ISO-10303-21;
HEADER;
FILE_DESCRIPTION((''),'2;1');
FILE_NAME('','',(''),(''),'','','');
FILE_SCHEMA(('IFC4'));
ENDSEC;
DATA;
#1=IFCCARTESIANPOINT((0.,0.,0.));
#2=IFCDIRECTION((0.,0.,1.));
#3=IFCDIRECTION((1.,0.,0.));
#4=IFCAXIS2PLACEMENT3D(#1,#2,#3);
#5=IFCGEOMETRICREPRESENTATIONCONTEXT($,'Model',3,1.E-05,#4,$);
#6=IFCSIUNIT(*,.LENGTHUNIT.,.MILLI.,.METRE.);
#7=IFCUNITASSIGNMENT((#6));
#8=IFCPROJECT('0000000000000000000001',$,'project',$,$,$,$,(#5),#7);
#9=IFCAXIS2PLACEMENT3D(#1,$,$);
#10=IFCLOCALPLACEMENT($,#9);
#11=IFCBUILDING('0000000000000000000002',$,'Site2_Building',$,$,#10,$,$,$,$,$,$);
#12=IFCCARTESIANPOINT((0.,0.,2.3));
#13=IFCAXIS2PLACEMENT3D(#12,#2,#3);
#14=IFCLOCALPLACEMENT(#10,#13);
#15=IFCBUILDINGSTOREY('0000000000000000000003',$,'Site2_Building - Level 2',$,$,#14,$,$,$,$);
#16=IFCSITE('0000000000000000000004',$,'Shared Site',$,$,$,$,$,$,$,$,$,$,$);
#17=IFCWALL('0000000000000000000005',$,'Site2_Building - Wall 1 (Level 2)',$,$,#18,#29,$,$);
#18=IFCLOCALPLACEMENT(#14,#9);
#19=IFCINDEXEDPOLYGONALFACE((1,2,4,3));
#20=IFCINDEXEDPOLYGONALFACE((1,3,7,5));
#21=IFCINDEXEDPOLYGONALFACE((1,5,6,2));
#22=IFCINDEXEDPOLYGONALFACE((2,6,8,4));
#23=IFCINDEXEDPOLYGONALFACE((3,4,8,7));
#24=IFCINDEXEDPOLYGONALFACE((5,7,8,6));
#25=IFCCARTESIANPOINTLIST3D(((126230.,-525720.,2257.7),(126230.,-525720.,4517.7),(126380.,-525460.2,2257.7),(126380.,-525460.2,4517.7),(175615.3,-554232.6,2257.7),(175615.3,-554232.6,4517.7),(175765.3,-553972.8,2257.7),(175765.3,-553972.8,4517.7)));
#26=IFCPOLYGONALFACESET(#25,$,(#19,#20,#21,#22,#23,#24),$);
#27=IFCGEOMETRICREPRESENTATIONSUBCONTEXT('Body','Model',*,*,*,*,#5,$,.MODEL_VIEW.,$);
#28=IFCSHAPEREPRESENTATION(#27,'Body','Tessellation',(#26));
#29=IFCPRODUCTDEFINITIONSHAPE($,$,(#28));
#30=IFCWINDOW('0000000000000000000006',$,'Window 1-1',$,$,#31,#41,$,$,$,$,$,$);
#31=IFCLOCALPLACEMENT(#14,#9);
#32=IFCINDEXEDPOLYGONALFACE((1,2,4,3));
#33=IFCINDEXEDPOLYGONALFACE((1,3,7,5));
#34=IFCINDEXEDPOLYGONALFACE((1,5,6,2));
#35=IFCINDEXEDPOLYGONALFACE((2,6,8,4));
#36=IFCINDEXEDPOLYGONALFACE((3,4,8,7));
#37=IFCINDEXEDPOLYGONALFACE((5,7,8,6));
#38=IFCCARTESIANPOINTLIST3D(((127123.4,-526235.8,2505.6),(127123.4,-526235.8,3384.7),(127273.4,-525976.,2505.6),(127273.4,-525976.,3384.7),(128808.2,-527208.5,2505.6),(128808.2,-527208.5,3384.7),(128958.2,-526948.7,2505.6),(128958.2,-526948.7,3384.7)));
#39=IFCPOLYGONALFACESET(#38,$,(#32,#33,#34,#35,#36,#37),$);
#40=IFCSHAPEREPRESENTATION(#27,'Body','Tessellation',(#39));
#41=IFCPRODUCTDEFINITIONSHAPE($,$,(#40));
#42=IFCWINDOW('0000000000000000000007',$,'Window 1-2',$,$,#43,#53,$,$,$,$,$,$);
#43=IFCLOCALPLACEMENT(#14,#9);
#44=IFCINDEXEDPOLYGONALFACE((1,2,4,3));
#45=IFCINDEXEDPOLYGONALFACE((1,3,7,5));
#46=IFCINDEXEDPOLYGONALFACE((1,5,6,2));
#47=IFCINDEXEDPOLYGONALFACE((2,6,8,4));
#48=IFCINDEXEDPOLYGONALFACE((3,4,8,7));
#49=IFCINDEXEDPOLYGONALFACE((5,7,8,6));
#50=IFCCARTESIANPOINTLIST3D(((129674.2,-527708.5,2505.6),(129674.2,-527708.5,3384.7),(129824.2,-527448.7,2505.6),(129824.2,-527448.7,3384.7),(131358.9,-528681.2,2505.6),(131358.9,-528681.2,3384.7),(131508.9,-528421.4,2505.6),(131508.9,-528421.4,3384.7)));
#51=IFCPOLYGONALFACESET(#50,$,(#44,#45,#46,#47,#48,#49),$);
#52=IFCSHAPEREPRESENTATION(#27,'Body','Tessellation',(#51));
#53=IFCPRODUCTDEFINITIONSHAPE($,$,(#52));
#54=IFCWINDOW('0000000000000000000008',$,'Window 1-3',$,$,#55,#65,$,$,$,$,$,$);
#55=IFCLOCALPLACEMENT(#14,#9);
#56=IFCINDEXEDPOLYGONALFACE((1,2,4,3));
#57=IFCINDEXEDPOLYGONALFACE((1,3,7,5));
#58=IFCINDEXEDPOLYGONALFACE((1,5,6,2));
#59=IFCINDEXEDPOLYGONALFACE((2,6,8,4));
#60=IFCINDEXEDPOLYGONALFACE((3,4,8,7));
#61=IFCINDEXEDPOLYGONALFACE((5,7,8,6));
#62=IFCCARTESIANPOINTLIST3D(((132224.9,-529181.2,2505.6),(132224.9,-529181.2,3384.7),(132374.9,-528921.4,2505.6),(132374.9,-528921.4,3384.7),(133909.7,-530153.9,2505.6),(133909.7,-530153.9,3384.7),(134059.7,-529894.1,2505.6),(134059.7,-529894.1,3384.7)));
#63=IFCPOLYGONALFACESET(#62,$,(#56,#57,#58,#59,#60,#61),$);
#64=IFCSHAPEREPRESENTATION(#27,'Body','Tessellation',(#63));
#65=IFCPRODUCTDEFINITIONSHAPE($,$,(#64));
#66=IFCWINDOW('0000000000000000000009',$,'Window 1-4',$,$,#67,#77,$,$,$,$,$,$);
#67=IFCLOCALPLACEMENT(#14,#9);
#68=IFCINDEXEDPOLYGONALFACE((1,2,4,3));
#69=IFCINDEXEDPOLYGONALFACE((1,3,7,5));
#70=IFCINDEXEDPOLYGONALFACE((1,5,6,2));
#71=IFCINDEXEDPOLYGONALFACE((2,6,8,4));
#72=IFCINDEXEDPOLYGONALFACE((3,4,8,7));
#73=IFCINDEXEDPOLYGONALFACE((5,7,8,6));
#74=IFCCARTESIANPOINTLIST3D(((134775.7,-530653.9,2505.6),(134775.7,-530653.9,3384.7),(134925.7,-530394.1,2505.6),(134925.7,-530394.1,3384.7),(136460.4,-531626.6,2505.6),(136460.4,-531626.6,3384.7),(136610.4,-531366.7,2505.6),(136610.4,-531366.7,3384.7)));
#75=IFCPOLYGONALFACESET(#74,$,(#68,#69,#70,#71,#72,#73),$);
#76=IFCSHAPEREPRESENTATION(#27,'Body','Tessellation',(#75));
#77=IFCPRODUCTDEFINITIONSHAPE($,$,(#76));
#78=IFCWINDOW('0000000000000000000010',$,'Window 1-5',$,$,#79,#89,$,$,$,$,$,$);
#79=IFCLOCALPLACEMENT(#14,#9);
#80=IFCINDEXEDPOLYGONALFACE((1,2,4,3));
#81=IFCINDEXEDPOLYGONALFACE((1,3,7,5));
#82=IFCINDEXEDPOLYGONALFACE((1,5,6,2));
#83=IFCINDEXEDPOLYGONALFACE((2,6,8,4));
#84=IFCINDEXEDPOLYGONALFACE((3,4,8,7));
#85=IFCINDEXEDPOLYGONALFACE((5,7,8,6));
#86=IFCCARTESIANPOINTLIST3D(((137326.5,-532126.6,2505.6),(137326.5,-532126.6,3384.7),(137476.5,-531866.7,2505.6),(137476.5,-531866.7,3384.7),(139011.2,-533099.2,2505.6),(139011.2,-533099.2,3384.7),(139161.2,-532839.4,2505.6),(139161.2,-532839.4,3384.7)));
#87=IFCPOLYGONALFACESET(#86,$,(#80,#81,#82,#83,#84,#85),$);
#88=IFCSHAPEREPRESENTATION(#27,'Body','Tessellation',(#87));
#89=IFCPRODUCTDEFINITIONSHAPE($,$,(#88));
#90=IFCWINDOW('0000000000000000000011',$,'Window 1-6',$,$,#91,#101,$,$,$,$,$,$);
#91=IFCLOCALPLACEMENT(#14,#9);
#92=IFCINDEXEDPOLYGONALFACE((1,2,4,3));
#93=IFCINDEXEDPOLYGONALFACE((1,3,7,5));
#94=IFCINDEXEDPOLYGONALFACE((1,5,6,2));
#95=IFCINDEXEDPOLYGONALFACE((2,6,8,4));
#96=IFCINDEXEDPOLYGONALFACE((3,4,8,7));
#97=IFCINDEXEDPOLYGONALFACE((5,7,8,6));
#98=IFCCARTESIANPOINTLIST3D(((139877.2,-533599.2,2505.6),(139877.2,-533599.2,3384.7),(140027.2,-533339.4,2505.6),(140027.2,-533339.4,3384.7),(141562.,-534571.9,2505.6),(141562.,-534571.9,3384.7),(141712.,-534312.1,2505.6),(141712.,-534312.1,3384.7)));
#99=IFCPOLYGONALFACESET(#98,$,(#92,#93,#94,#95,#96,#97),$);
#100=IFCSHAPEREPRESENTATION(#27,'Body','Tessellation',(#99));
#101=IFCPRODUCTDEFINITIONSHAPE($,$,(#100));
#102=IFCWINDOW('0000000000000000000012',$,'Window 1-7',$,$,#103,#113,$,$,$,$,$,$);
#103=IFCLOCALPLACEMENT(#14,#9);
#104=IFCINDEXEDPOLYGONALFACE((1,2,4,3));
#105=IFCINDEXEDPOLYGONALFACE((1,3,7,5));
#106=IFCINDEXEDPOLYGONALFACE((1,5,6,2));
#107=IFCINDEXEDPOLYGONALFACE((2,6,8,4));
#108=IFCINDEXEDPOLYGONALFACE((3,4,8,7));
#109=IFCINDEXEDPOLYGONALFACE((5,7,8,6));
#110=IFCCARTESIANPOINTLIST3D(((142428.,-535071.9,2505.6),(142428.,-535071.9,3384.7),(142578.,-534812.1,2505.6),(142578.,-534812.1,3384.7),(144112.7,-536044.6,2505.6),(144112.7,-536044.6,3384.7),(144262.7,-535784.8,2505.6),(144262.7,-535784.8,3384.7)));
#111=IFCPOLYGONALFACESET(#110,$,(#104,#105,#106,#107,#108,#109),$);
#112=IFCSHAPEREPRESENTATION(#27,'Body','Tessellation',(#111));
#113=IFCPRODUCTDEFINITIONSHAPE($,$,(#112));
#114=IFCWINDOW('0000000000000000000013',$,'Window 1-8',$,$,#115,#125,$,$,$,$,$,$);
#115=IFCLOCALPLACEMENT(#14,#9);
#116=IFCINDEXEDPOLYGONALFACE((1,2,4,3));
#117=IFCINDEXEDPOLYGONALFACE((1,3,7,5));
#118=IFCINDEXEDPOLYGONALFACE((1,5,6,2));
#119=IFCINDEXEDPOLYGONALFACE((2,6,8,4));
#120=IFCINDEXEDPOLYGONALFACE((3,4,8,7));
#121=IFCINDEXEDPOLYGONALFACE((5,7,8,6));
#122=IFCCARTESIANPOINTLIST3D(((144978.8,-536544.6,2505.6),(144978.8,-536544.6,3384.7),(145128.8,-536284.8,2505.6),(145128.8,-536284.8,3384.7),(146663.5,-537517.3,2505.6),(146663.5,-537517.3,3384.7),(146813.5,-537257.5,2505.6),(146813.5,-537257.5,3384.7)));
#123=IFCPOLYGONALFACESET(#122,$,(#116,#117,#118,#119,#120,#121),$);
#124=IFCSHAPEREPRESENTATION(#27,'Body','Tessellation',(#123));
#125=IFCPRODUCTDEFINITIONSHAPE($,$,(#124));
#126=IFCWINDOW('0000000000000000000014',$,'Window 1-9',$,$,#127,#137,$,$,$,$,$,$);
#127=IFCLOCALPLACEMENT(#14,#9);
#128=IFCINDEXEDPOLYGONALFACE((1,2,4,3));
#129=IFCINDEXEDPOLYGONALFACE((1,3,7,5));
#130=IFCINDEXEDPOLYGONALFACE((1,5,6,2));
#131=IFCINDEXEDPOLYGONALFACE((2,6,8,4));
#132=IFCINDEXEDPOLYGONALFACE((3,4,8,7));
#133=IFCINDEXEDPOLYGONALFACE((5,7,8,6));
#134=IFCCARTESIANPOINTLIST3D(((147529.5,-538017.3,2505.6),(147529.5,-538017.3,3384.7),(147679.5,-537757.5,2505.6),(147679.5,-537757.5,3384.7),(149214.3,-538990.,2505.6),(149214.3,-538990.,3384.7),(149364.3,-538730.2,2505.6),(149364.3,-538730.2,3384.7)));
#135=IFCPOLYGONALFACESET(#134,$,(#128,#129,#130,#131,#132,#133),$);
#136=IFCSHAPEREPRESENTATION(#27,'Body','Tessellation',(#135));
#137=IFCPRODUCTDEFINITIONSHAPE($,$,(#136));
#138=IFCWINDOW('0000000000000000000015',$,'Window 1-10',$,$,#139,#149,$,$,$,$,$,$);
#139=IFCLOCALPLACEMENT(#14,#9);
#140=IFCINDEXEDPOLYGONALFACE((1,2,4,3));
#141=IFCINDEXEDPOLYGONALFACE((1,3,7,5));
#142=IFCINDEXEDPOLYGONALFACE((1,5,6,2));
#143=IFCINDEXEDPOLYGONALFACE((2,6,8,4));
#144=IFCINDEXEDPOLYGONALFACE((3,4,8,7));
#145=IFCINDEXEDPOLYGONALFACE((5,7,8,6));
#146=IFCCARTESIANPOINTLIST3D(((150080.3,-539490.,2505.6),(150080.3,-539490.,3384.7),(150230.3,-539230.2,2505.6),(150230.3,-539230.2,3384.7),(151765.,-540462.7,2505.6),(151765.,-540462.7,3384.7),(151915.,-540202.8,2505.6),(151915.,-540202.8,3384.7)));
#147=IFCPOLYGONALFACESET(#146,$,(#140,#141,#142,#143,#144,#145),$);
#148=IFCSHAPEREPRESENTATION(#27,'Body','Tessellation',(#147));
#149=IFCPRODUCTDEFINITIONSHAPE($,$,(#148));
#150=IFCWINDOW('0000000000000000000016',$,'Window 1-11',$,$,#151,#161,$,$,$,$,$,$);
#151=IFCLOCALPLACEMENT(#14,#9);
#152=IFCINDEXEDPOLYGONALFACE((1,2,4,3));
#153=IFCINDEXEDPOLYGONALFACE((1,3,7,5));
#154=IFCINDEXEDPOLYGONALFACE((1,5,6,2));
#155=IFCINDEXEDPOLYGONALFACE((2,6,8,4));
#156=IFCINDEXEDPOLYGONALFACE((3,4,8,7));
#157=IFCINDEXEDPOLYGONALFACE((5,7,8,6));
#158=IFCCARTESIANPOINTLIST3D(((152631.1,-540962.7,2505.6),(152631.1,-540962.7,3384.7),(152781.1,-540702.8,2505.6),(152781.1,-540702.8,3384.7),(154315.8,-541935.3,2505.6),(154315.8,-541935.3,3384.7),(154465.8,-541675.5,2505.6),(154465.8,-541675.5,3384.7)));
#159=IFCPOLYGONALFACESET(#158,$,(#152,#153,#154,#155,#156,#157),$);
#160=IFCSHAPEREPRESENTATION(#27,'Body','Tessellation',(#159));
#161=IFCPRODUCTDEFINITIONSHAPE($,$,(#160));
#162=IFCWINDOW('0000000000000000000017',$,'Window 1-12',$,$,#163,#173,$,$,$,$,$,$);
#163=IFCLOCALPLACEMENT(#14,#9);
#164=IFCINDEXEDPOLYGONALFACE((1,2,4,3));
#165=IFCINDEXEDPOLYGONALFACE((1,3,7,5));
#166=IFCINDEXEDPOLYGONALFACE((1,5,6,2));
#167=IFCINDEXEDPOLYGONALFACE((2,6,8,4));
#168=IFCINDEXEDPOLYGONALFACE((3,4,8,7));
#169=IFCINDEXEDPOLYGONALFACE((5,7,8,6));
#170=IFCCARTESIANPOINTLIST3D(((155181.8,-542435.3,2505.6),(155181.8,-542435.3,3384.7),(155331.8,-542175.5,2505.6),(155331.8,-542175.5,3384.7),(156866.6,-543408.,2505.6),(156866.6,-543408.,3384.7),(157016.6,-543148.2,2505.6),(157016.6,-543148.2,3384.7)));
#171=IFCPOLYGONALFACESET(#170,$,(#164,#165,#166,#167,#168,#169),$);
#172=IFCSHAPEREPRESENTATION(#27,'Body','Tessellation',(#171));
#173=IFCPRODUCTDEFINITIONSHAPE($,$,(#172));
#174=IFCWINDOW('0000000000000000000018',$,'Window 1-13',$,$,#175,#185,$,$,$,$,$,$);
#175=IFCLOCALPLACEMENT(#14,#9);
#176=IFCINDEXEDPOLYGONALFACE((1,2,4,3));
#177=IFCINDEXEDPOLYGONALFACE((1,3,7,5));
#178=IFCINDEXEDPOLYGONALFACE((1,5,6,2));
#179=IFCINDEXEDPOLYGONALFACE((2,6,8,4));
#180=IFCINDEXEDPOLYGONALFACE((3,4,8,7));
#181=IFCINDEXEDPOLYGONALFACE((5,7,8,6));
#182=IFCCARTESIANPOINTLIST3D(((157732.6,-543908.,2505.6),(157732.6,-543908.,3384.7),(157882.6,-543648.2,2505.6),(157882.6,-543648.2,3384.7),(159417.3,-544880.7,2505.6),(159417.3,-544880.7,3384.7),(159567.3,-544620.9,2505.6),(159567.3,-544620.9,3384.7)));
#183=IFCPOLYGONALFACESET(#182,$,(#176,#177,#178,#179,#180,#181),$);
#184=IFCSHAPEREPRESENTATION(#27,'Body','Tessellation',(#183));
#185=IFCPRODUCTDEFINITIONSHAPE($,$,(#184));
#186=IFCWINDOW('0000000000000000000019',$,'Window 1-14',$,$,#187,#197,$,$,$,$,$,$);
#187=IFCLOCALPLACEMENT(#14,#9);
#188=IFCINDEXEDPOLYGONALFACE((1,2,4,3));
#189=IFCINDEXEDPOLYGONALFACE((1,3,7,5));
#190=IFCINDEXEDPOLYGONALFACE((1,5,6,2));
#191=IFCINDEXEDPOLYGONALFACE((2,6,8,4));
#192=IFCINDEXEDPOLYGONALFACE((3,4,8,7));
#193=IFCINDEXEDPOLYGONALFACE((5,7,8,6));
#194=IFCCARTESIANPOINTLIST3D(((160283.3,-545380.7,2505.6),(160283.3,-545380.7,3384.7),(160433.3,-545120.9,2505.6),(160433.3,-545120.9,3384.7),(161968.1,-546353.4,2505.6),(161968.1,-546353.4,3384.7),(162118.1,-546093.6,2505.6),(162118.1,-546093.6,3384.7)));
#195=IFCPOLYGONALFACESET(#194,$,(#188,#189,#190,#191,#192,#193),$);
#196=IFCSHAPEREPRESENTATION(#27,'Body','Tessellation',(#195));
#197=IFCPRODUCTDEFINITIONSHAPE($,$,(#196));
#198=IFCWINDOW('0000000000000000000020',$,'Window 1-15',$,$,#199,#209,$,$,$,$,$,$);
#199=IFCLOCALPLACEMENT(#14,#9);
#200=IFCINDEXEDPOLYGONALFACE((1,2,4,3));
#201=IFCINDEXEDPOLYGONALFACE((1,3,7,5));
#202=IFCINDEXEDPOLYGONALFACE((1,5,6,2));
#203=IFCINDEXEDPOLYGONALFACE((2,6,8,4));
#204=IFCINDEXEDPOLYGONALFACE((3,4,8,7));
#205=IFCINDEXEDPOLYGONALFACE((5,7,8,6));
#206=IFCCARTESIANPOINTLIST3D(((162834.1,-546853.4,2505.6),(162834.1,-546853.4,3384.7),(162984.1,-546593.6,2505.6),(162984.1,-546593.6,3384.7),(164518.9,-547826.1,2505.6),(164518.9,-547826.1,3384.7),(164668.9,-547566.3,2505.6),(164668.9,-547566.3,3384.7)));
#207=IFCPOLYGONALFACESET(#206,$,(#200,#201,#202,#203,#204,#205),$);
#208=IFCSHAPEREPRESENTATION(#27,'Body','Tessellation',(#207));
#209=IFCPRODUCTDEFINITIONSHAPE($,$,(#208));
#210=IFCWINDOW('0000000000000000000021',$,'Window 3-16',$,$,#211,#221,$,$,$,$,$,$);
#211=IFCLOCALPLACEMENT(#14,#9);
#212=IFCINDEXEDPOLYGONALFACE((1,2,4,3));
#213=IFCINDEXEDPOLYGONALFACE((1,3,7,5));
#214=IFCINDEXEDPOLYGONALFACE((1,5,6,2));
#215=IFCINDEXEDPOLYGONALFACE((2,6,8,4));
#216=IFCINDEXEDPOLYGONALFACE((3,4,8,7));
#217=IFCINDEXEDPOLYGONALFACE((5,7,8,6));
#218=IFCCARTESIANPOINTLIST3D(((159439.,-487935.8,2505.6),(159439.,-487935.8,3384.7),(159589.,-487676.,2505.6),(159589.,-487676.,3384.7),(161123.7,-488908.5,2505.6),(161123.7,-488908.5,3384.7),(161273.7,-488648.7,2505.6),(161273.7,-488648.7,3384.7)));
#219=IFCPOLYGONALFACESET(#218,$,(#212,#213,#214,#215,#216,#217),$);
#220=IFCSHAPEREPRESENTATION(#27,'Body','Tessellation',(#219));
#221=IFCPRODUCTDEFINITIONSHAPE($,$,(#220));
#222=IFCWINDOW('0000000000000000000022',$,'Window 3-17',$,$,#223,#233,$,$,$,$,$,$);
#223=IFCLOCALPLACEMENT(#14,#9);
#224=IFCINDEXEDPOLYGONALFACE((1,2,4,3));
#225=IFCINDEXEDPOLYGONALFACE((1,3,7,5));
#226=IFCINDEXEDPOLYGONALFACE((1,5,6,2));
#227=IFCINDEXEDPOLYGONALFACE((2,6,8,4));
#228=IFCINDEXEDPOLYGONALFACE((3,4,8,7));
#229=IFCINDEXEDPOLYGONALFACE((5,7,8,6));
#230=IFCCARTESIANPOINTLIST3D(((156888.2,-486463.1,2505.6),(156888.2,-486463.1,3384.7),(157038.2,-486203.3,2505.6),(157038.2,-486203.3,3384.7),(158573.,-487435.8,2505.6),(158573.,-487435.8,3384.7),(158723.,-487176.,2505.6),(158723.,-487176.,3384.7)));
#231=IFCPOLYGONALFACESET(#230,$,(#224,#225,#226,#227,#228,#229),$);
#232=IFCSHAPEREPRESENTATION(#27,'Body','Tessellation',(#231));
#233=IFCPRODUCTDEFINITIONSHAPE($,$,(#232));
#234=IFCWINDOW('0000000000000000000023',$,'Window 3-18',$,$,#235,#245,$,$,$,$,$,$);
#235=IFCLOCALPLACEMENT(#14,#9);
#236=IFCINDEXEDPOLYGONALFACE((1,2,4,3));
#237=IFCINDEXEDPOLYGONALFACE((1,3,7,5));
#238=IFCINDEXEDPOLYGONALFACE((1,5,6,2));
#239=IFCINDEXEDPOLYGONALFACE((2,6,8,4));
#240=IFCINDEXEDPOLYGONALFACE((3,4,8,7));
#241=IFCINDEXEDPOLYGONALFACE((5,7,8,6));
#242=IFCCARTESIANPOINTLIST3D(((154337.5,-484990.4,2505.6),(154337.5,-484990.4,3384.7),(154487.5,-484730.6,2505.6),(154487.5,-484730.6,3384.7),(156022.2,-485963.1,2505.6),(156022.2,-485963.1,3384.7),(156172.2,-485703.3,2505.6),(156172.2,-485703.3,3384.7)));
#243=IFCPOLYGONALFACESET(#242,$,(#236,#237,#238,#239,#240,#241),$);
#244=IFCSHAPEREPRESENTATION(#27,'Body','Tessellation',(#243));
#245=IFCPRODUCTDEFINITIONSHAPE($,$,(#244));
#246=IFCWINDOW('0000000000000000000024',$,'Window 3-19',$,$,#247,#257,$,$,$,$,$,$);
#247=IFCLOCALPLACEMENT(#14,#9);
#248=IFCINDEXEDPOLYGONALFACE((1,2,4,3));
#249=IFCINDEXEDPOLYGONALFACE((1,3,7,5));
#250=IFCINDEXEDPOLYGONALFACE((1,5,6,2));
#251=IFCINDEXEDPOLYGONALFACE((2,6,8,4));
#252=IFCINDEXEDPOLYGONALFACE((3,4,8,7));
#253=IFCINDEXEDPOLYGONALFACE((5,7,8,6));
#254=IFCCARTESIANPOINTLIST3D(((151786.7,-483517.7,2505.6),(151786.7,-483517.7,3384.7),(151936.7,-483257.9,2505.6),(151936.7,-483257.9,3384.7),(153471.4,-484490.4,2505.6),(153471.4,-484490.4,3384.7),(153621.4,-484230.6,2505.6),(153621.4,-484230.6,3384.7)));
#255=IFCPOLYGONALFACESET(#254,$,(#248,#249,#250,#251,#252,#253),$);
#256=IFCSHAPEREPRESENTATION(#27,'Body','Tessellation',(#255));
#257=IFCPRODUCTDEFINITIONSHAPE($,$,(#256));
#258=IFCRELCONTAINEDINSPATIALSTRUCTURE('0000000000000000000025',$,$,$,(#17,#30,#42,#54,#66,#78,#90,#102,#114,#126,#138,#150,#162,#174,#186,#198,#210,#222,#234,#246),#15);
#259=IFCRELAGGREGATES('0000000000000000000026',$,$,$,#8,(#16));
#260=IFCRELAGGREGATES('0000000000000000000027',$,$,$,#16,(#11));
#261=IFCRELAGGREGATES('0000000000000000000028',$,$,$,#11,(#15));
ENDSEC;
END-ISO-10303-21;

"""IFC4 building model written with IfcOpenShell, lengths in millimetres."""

from ifc_helpers import new_model, si_unit, frame, origin, origin_with_axes, place, context, subcontext, project, spatial, indexed_curve, outline, extrude, element, save


model = new_model("IFC4")

# Units and contexts
model_context = context("Model", 3, precision=1e-05, world=origin_with_axes())
body_context = subcontext(model_context, "Body", "Model", "MODEL_VIEW")
ifc_project = project(units=[si_unit("LENGTHUNIT", "METRE", prefix="MILLI")], contexts=[model_context])

# Site, building, storey
site = spatial("IfcSite", under=ifc_project, Name="Shared Site")
building_placement = place(None, origin())
building = spatial("IfcBuilding", under=site, at=building_placement, Name="Site2_Building")
storey_placement = place(building_placement, frame((0.0, 0.0, 2.3), z_axis=(0.0, 0.0, 1.0), x_axis=(1.0, 0.0, 0.0)))
storey = spatial("IfcBuildingStorey", under=building, at=storey_placement, Name="Site2_Building - Level 2")

# Wall
wall_1_placement = place(storey_placement, frame((126230.0, -525720.0, 2257.7), z_axis=(0.0, 0.0, 1.0), x_axis=(0.866025, -0.5, 0.0)))
element("IfcWall", 1, at=wall_1_placement, inside=storey, Name="Site2_Building - Wall 1 (Level 2)", context=body_context, shape_type="SweptSolid", body=[
    extrude(outline(indexed_curve([(0.0, 0.0), (0.0, 300.0), (57025.3, 300.0), (57025.3, 0.0), (0.0, 0.0)], self_intersect=False)), origin_with_axes(), (0.0, 0.0, 1.0), 2260.0),
])

# Windows
for number, where, z_axis, x_axis, name in (
    (2, (127123.4, -526235.8, 2505.6), (0.0, 0.0, 1.0), (0.866025, -0.5, 0.0), "Window 1-1"),
    (3, (129674.2, -527708.5, 2505.6), (0.0, 0.0, 1.0), (0.866025, -0.5, 0.0), "Window 1-2"),
    (4, (132224.9, -529181.2, 2505.6), (0.0, 0.0, 1.0), (0.866025, -0.5, 0.0), "Window 1-3"),
    (5, (134775.7, -530653.9, 2505.6), (0.0, 0.0, 1.0), (0.866025, -0.5, 0.0), "Window 1-4"),
    (6, (137326.5, -532126.6, 2505.6), (0.0, 0.0, 1.0), (0.866025, -0.5, 0.0), "Window 1-5"),
    (7, (139877.2, -533599.2, 2505.6), (0.0, 0.0, 1.0), (0.866025, -0.5, 0.0), "Window 1-6"),
    (8, (142428.0, -535071.9, 2505.6), (0.0, 0.0, 1.0), (0.866025, -0.5, 0.0), "Window 1-7"),
    (9, (144978.8, -536544.6, 2505.6), (0.0, 0.0, 1.0), (0.866025, -0.5, 0.0), "Window 1-8"),
    (10, (147529.5, -538017.3, 2505.6), (0.0, 0.0, 1.0), (0.866025, -0.5, 0.0), "Window 1-9"),
    (11, (150080.3, -539490.0, 2505.6), (0.0, 0.0, 1.0), (0.866025, -0.5, 0.0), "Window 1-10"),
    (12, (152631.1, -540962.7, 2505.6), (0.0, 0.0, 1.0), (0.866025, -0.5, 0.0), "Window 1-11"),
    (13, (155181.8, -542435.3, 2505.6), (0.0, 0.0, 1.0), (0.866025, -0.5, 0.0), "Window 1-12"),
    (14, (157732.6, -543908.0, 2505.6), (0.0, 0.0, 1.0), (0.866025, -0.5, 0.0), "Window 1-13"),
    (15, (160283.3, -545380.7, 2505.6), (0.0, 0.0, 1.0), (0.866025, -0.5, 0.0), "Window 1-14"),
    (16, (162834.1, -546853.4, 2505.6), (0.0, 0.0, 1.0), (0.866025, -0.5, 0.0), "Window 1-15"),
    (17, (161273.7, -488648.7, 2505.6), (0.0, 0.0, 1.0), (-0.866025, 0.5, 0.0), "Window 3-16"),
    (18, (158723.0, -487176.0, 2505.6), (0.0, 0.0, 1.0), (-0.866025, 0.5, 0.0), "Window 3-17"),
    (19, (156172.2, -485703.3, 2505.6), (0.0, 0.0, 1.0), (-0.866025, 0.5, 0.0), "Window 3-18"),
    (20, (153621.4, -484230.6, 2505.6), (0.0, 0.0, 1.0), (-0.866025, 0.5, 0.0), "Window 3-19"),
):
    element("IfcWindow", number, at=place(storey_placement, frame(where, z_axis=z_axis, x_axis=x_axis)), inside=storey, Name=name, context=body_context, shape_type="SweptSolid", body=[
        extrude(outline(indexed_curve([(0.0, 0.0), (0.0, 300.0), (1945.4, 300.0), (1945.4, 0.0), (0.0, 0.0)], self_intersect=False)), origin_with_axes(), (0.0, 0.0, 1.0), 879.1),
    ])

save(model, "model.ifc")
